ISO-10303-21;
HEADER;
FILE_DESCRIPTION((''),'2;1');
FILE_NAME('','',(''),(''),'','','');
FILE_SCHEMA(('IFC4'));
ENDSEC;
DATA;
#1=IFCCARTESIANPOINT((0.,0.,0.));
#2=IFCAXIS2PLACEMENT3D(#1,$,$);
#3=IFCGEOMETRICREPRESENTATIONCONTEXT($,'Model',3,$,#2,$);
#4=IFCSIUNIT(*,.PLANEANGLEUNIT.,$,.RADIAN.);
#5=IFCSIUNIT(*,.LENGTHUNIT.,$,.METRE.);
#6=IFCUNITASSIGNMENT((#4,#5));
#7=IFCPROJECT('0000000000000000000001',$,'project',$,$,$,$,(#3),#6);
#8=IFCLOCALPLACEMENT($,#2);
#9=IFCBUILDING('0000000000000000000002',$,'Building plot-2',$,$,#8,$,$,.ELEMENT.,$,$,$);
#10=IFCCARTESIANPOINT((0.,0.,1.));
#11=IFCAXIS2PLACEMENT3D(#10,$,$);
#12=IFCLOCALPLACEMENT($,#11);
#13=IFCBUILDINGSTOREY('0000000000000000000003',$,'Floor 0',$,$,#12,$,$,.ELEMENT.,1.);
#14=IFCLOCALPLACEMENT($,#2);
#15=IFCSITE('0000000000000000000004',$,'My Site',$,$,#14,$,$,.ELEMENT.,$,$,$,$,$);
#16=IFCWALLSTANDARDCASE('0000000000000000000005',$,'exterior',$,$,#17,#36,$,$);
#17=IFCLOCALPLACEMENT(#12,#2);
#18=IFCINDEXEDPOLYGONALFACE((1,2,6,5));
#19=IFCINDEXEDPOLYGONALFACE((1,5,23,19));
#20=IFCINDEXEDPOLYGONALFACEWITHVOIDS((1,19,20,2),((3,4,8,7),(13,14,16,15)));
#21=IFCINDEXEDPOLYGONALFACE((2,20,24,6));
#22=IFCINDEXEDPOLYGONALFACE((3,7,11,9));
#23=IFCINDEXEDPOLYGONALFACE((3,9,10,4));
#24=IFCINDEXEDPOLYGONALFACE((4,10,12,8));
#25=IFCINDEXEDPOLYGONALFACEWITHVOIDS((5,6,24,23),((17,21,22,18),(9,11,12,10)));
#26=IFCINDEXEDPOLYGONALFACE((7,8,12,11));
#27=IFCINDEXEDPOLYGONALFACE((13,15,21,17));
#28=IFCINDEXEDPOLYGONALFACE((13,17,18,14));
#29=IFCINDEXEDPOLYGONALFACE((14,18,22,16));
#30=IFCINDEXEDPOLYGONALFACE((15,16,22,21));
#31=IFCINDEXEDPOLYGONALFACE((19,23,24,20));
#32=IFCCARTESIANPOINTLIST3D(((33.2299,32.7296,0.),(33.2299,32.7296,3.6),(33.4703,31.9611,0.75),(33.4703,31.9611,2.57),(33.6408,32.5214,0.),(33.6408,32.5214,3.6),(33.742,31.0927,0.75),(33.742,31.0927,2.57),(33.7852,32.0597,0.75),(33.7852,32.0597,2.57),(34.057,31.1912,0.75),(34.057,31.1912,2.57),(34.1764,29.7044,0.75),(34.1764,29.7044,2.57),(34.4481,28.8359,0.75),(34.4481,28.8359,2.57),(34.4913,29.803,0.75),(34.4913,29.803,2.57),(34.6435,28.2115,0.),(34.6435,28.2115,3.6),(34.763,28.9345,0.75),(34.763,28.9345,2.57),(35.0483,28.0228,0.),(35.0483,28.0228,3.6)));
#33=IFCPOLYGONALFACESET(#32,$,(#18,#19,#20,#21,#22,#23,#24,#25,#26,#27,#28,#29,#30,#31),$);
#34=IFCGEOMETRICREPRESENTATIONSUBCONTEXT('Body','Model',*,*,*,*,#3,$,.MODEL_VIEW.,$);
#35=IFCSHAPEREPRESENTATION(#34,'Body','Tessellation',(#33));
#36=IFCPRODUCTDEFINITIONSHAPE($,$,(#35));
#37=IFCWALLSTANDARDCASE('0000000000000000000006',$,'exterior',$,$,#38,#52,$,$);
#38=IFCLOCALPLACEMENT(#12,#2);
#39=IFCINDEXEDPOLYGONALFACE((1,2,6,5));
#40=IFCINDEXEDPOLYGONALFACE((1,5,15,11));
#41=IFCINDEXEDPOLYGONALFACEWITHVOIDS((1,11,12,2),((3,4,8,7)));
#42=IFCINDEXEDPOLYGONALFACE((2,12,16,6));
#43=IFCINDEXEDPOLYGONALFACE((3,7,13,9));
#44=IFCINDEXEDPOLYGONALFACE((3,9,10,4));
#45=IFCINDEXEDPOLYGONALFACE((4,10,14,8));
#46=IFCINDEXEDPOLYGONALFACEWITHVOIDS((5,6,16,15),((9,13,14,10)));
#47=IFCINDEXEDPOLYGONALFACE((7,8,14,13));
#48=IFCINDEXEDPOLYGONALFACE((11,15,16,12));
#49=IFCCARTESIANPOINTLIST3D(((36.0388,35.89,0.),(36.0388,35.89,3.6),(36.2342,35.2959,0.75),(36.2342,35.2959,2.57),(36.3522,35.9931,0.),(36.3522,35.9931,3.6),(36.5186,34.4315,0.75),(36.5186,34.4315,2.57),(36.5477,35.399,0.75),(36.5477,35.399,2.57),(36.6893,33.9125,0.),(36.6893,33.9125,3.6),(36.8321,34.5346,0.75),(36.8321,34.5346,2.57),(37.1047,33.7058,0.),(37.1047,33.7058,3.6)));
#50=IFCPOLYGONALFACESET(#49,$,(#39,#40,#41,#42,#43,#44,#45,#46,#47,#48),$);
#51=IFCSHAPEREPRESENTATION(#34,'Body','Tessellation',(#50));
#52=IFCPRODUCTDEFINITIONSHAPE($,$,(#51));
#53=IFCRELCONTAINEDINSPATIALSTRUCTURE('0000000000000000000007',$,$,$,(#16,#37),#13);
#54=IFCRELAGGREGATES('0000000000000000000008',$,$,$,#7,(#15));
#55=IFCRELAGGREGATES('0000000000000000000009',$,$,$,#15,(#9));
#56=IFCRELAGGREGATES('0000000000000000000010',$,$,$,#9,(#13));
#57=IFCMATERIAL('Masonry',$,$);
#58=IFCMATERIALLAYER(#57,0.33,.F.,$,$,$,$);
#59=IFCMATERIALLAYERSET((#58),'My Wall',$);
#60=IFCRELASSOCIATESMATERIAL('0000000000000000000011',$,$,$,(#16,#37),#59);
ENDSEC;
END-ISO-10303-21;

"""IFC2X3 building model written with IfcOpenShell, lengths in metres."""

from ifc_helpers import new_model, si_unit, frame, origin, place, context, subcontext, project, spatial, polyline, outline, extrude, material, layer, layer_set, layer_usage, element, save


model = new_model("IFC2X3")

# Units and contexts
model_context = context("Model", 3, world=origin())
body_context = subcontext(model_context, "Body", "Model", "MODEL_VIEW")
ifc_project = project(units=[si_unit("PLANEANGLEUNIT", "RADIAN"), si_unit("LENGTHUNIT", "METRE")], contexts=[model_context])

# Site, building, storey
site_placement = place(None, origin())
site = spatial("IfcSite", under=ifc_project, at=site_placement, Name="My Site", CompositionType="ELEMENT")
building_placement = place(None, origin())
building = spatial("IfcBuilding", under=site, at=building_placement, Name="Building plot-2", CompositionType="ELEMENT")
storey_placement = place(None, frame((0.0, 0.0, 1.0)))
storey = spatial("IfcBuildingStorey", under=building, at=storey_placement, Name="Floor 0", CompositionType="ELEMENT", Elevation=1.0)

# Shared definitions
ifc_material = material(Name="Masonry")
ifc_layer = layer(ifc_material, 0.33, ventilated=False)
ifc_layer_set = layer_set([ifc_layer], Name="My Wall")
ifc_layer_usage = layer_usage(ifc_layer_set, "AXIS2", "NEGATIVE", 0.08)

# Wall, openings
wall_1_placement = place(storey_placement, origin())
wall_1 = element("IfcWallStandardCase", 1, at=wall_1_placement, inside=storey, material=ifc_layer_usage, Name="exterior", context=body_context, shape_type="SweptSolid", body=[
    extrude(outline(polyline([(34.6435, 28.2115), (35.0483, 28.0228), (33.6408, 32.5214), (33.2299, 32.7296), (34.6435, 28.2115)])), origin(), (0.0, 0.0, 1.0), 3.6),
])
opening_1_placement = place(storey_placement, frame((0.0, 0.0, 0.75)))
element("IfcOpeningElement", 2, at=opening_1_placement, cuts=wall_1, ObjectType="Opening", context=body_context, shape_type="SweptSolid", body=[
    extrude(outline(polyline([(34.763, 28.9345), (34.4913, 29.803), (34.1764, 29.7044), (34.4481, 28.8359), (34.763, 28.9345)])), origin(), (0.0, 0.0, 1.0), 1.82),
])
opening_2_placement = place(storey_placement, frame((0.0, 0.0, 0.75)))
element("IfcOpeningElement", 3, at=opening_2_placement, cuts=wall_1, ObjectType="Opening", context=body_context, shape_type="SweptSolid", body=[
    extrude(outline(polyline([(34.057, 31.1912), (33.7852, 32.0597), (33.4703, 31.9611), (33.742, 31.0927), (34.057, 31.1912)])), origin(), (0.0, 0.0, 1.0), 1.82),
])

# Wall, opening
wall_2_placement = place(storey_placement, origin())
wall_2 = element("IfcWallStandardCase", 4, at=wall_2_placement, inside=storey, material=ifc_layer_usage, Name="exterior", context=body_context, shape_type="SweptSolid", body=[
    extrude(outline(polyline([(36.6893, 33.9125), (37.1047, 33.7058), (36.3522, 35.9931), (36.0388, 35.89), (36.6893, 33.9125)])), origin(), (0.0, 0.0, 1.0), 3.6),
])
opening_3_placement = place(storey_placement, frame((0.0, 0.0, 0.75)))
element("IfcOpeningElement", 5, at=opening_3_placement, cuts=wall_2, ObjectType="Opening", context=body_context, shape_type="SweptSolid", body=[
    extrude(outline(polyline([(36.8321, 34.5346), (36.5477, 35.399), (36.2342, 35.2959), (36.5186, 34.4315), (36.8321, 34.5346)])), origin(), (0.0, 0.0, 1.0), 1.82),
])

save(model, "model.ifc")
